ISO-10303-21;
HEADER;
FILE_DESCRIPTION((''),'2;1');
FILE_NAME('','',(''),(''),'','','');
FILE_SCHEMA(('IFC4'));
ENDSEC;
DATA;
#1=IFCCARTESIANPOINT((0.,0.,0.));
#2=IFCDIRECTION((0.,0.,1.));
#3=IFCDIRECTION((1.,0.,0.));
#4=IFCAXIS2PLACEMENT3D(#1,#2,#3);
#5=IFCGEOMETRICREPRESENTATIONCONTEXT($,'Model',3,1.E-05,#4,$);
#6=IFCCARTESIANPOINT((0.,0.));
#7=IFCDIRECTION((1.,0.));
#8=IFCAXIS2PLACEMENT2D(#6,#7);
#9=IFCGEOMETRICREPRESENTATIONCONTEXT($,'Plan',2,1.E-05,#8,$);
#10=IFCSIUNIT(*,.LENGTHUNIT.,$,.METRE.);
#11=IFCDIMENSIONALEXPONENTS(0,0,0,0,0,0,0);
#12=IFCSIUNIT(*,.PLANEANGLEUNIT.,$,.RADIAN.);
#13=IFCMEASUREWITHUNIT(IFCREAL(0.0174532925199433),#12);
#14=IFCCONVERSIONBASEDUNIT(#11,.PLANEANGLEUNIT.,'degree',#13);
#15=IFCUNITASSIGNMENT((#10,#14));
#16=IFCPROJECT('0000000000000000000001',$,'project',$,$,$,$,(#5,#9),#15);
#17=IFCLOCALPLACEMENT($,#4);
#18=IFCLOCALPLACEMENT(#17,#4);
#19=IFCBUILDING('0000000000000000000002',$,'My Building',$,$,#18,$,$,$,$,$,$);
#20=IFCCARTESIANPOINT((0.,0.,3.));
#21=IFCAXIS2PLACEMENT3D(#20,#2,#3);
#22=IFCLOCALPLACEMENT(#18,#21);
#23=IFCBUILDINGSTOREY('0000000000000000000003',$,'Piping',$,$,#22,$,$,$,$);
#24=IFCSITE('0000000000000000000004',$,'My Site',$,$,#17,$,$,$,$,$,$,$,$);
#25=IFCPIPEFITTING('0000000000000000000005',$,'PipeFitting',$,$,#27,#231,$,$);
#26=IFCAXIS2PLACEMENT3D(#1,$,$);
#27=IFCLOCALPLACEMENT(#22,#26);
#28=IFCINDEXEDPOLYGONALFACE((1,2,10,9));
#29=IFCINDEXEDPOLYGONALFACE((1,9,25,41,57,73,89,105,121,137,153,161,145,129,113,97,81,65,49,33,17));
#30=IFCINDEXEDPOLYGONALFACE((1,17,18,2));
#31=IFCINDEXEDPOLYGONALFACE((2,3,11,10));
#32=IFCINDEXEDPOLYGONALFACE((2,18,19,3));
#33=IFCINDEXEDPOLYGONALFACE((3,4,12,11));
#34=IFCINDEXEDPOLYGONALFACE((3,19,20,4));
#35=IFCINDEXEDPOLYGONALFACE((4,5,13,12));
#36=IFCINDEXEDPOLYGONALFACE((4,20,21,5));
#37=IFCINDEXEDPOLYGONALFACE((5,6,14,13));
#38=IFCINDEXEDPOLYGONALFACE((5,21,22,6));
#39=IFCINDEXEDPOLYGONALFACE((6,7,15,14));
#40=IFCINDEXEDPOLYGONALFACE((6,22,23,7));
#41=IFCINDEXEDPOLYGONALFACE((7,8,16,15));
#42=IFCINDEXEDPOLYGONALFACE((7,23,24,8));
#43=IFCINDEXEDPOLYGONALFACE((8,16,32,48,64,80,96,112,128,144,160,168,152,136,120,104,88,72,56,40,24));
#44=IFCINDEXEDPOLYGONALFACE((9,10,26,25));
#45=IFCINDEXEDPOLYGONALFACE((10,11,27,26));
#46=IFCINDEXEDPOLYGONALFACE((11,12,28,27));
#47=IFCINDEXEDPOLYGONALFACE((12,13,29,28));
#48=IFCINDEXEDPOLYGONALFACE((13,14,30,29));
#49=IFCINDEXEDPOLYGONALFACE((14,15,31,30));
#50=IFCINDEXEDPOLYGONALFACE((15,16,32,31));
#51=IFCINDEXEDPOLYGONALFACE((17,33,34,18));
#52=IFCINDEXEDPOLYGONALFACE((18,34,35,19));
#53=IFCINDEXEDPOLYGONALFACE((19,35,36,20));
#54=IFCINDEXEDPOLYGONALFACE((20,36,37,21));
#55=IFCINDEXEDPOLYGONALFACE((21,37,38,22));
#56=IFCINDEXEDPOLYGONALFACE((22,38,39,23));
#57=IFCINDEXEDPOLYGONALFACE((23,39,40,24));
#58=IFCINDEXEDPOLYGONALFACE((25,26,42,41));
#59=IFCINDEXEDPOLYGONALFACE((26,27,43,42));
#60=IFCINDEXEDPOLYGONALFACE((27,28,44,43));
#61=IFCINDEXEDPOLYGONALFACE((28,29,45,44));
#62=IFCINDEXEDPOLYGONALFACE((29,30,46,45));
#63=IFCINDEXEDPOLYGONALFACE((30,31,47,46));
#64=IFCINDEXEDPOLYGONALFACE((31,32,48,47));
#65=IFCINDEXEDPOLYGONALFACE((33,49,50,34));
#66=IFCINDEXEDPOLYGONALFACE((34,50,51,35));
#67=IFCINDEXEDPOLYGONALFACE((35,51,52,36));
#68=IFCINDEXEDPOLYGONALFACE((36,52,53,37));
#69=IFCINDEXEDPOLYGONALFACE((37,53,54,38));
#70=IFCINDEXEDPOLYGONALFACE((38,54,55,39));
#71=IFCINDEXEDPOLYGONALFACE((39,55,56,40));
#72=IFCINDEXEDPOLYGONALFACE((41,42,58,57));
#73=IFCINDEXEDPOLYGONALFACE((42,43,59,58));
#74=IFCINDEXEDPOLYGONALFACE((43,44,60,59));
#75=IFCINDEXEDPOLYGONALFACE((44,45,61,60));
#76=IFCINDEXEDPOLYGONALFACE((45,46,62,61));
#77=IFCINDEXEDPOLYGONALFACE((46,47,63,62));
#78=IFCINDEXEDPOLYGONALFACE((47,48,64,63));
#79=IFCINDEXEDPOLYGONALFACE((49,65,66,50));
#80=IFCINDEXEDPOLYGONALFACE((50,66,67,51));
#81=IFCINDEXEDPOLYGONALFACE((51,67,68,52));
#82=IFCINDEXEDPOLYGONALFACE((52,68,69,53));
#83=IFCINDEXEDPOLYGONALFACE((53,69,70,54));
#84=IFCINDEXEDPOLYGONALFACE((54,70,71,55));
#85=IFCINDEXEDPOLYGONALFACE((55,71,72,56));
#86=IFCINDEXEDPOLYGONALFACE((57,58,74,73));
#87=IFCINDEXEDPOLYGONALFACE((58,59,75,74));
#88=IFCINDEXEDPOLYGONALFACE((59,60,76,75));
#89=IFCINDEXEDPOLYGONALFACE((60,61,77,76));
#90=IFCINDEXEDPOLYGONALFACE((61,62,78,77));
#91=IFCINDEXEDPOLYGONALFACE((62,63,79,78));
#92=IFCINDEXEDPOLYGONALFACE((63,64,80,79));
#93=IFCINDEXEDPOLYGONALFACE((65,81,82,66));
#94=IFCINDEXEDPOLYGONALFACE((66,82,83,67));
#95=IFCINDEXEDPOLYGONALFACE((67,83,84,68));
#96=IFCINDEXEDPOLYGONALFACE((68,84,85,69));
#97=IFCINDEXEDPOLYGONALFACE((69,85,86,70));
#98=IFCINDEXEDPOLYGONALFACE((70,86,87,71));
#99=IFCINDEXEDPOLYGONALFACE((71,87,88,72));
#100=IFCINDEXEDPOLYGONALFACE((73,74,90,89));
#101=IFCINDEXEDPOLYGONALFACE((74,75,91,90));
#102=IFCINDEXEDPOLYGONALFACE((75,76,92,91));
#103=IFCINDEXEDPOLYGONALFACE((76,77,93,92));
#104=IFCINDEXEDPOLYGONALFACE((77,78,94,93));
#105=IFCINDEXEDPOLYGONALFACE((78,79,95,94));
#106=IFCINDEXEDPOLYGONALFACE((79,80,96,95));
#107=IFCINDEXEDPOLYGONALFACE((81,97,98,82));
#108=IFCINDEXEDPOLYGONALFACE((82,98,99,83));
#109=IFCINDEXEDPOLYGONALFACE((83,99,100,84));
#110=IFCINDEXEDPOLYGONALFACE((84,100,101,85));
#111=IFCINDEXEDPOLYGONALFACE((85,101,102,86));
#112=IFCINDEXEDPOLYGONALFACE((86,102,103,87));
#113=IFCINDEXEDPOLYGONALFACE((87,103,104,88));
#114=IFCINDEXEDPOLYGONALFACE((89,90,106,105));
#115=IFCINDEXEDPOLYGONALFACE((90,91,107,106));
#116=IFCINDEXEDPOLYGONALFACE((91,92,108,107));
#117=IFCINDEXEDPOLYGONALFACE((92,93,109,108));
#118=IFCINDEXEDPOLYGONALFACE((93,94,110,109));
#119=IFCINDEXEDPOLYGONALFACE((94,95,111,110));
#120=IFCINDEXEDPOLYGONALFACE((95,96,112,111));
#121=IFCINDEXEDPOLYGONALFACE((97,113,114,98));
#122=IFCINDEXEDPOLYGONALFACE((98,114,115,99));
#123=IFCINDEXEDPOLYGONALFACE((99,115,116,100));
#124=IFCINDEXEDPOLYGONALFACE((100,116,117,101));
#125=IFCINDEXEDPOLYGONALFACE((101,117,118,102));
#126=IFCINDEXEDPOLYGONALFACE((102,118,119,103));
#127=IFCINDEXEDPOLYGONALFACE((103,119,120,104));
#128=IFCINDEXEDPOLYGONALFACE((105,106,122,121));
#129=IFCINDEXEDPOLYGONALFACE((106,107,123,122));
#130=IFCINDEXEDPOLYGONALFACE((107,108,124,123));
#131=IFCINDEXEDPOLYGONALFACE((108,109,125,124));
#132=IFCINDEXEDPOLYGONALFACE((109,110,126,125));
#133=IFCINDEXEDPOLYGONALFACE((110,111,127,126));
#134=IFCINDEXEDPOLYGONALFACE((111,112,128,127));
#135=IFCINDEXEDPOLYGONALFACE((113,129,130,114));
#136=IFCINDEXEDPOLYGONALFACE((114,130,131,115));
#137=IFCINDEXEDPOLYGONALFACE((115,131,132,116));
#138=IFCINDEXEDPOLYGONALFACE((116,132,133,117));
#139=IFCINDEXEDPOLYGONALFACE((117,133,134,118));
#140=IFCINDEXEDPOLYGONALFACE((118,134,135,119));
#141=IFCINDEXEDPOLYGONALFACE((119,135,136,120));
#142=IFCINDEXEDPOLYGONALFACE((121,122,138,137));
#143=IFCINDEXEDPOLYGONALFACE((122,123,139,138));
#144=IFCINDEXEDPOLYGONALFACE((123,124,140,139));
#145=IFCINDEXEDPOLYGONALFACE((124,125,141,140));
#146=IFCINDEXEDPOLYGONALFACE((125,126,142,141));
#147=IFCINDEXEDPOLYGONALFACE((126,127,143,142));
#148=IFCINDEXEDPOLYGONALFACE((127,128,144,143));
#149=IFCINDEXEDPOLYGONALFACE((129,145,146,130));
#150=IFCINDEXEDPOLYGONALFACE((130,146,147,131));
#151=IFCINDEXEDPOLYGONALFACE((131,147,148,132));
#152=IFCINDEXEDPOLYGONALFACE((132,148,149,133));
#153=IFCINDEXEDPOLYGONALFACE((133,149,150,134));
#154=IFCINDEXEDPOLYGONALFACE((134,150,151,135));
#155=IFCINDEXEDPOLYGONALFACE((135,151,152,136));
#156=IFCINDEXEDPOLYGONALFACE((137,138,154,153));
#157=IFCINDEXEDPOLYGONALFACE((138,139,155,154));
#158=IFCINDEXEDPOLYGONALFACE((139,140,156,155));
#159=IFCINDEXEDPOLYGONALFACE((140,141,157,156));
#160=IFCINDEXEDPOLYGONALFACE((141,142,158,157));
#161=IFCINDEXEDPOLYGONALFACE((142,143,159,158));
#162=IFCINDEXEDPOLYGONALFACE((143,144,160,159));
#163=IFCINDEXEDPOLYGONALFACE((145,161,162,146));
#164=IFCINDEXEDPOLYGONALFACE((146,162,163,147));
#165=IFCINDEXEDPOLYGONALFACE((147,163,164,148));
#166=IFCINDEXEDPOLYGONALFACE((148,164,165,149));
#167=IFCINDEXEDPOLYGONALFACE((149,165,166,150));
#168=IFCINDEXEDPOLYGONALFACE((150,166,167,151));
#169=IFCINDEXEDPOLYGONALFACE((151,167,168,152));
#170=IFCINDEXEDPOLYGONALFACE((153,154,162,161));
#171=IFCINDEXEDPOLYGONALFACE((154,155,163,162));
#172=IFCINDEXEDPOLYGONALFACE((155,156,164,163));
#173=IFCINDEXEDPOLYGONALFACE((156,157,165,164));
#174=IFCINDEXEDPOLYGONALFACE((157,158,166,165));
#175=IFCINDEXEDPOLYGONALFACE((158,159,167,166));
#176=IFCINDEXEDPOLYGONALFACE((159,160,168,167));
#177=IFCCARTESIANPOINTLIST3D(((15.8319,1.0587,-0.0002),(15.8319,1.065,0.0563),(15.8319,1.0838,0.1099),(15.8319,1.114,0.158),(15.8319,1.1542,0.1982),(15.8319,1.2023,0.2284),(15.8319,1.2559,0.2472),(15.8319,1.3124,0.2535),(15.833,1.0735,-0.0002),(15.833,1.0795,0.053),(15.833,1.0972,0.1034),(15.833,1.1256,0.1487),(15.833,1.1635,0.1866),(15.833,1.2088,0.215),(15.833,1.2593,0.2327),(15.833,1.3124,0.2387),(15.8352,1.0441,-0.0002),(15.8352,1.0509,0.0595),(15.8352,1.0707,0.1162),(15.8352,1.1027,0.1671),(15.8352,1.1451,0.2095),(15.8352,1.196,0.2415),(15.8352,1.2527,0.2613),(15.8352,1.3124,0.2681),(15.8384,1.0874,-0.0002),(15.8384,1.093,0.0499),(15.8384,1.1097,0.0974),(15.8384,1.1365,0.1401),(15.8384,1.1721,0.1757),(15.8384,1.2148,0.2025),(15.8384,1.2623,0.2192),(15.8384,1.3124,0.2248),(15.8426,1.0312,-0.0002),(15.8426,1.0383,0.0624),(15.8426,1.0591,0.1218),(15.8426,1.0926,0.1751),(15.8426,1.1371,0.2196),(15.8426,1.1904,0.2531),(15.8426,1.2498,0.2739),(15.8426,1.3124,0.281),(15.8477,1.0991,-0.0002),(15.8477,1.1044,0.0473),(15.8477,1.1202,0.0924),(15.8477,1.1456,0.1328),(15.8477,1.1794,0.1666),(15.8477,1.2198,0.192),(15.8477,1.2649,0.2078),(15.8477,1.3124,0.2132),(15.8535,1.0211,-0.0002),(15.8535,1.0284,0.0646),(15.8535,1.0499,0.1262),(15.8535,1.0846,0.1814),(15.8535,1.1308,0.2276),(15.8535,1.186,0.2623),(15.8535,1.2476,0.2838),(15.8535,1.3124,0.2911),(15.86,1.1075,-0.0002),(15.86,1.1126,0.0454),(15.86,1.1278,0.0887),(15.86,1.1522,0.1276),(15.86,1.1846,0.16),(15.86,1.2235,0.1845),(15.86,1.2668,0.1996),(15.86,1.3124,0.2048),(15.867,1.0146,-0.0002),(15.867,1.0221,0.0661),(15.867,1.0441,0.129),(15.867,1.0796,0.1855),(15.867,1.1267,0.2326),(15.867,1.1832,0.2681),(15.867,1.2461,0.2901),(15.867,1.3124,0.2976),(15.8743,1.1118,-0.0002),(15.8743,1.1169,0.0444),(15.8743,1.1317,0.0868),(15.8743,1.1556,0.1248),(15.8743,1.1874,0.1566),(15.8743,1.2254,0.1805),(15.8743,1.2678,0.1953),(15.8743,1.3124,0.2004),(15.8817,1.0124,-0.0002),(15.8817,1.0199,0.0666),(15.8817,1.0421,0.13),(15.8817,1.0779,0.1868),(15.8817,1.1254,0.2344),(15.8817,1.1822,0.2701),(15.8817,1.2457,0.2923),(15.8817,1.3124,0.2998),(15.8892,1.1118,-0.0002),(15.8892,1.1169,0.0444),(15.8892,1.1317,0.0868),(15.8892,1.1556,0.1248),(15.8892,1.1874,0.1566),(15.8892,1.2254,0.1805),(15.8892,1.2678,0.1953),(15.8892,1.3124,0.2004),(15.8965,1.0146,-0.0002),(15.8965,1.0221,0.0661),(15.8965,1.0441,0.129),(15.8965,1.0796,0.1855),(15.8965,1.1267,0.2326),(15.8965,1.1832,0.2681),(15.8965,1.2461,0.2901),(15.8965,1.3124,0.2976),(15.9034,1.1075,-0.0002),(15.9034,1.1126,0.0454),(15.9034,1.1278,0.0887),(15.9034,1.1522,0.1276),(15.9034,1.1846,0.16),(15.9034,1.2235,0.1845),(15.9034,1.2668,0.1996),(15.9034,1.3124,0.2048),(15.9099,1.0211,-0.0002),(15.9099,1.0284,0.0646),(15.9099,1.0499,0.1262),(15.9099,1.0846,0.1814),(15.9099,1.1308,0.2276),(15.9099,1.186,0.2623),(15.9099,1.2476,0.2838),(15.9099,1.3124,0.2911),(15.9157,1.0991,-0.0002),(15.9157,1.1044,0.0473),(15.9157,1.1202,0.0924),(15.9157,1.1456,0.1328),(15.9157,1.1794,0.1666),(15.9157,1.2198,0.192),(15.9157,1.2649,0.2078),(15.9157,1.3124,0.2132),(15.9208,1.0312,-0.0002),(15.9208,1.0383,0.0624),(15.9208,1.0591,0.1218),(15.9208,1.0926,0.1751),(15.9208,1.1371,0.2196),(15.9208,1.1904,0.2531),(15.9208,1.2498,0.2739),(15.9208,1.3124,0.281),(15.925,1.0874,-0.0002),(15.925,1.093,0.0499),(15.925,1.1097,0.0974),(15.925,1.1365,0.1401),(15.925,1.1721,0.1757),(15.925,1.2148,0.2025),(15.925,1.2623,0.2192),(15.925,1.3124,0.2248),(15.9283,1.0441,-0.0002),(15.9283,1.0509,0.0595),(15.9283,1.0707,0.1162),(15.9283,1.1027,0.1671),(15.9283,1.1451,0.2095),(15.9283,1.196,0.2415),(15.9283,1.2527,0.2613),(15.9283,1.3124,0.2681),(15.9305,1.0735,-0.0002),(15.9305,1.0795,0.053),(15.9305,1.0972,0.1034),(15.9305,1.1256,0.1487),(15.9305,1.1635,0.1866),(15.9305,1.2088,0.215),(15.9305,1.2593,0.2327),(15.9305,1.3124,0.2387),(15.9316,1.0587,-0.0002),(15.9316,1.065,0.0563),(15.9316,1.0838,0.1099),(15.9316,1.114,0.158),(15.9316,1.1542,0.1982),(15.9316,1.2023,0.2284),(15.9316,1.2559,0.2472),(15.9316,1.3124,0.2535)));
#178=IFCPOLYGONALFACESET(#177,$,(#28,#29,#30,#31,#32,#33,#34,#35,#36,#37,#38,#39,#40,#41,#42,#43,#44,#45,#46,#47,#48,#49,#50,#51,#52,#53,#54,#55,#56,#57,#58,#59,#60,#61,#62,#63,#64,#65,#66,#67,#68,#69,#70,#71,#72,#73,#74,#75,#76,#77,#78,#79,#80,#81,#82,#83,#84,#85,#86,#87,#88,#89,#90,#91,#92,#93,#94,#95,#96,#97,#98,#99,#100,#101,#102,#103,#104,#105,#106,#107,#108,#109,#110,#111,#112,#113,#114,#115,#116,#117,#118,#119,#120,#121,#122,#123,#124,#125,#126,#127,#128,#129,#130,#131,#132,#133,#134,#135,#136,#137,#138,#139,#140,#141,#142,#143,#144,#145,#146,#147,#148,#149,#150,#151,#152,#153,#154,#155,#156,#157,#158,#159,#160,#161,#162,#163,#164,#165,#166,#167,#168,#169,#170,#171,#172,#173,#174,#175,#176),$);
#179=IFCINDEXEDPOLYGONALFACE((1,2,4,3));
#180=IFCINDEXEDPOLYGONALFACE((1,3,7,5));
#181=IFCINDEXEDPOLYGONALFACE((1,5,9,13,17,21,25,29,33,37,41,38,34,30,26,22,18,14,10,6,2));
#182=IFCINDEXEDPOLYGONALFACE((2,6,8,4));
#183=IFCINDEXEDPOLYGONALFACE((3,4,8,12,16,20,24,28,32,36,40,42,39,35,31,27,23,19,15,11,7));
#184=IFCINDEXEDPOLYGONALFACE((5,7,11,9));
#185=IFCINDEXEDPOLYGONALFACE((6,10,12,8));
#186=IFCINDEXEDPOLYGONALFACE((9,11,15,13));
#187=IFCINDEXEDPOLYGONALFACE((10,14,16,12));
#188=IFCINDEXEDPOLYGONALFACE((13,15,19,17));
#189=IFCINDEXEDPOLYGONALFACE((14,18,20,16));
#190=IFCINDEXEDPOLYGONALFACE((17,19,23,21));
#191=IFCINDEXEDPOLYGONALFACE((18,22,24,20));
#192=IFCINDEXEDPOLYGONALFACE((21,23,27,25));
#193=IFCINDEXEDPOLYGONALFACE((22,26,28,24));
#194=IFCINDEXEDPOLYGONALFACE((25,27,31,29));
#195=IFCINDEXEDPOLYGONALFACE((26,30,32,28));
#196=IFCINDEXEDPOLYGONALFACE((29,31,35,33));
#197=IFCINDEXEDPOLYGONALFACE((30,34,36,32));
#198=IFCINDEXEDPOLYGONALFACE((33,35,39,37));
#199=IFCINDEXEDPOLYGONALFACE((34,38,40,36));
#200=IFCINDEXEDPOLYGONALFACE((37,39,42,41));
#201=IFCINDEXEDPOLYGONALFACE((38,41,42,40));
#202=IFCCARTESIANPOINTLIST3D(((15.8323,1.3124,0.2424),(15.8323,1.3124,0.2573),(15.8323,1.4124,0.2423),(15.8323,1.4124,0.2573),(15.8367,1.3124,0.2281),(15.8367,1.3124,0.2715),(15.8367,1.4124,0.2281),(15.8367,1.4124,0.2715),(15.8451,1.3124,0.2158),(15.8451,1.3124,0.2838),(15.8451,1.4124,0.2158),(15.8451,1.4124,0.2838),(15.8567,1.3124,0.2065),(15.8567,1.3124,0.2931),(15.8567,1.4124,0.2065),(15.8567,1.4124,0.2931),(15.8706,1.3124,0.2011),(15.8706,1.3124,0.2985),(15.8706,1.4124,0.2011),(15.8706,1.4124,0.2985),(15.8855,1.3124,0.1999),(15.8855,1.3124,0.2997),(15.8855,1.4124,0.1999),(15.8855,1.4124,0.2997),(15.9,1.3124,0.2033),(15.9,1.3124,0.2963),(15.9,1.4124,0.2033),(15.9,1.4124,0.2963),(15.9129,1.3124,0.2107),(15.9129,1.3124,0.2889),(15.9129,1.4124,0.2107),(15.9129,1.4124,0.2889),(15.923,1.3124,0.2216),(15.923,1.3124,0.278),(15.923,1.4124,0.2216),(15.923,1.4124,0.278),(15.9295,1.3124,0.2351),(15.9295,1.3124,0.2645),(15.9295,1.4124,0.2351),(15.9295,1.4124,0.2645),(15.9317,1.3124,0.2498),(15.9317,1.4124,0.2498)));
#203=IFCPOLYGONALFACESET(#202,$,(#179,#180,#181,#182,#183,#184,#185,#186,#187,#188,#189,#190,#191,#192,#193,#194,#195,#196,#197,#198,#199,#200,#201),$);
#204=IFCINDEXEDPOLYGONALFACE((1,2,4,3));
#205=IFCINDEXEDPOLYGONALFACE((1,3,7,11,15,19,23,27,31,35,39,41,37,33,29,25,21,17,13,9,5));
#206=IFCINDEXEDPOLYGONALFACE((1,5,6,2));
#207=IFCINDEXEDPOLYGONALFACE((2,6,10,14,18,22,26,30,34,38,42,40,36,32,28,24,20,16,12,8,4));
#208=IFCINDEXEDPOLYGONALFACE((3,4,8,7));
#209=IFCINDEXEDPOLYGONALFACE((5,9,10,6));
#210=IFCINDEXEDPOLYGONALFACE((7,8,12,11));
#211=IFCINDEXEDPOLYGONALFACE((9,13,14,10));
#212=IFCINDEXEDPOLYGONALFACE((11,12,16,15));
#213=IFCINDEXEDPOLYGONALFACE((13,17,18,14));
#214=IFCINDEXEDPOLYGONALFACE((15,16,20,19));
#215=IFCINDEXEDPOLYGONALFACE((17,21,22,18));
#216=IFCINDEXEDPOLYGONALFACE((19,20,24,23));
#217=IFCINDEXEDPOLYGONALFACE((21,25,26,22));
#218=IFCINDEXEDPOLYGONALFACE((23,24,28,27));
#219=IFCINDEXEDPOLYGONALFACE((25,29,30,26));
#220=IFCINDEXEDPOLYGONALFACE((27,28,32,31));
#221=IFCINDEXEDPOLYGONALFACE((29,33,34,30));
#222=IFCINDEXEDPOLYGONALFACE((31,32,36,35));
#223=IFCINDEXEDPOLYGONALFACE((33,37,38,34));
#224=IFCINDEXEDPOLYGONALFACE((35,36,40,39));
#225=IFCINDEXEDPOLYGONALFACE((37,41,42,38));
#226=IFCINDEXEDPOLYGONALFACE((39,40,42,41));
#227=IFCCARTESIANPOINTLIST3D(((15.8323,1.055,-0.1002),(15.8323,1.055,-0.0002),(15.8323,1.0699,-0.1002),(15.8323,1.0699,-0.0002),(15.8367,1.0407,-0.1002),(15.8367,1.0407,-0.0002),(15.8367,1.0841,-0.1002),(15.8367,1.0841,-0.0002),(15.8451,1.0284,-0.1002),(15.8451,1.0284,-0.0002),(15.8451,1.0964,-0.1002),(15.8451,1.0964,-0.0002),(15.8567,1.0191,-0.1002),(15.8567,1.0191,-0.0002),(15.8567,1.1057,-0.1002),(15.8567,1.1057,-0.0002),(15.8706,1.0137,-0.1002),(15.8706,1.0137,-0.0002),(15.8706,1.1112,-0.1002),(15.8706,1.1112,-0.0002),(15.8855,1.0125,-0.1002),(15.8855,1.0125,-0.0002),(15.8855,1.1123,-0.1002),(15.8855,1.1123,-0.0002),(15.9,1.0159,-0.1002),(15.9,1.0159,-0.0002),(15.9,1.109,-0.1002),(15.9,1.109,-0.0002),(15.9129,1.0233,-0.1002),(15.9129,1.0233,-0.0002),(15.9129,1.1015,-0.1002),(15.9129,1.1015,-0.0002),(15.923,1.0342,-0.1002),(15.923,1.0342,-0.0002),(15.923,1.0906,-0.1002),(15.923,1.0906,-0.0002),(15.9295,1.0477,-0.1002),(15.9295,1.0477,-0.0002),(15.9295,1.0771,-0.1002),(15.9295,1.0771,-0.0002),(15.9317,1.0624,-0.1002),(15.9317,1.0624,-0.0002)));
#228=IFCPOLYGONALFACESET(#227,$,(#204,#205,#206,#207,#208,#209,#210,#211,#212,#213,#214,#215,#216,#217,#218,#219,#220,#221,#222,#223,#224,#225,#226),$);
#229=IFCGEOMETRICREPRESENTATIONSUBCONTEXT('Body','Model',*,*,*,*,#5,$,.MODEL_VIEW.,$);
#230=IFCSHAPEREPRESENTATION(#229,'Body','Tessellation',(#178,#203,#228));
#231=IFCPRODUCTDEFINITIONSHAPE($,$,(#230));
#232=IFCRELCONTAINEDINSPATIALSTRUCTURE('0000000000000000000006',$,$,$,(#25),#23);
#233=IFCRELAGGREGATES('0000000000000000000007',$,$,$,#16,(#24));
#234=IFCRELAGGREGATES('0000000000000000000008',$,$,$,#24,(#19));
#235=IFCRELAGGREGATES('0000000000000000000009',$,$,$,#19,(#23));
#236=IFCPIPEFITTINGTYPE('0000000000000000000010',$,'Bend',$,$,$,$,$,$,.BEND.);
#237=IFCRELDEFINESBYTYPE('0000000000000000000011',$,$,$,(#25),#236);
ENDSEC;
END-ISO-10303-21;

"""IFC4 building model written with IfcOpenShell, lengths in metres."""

from ifc_helpers import new_model, entity, si_unit, converted_unit, frame, origin_with_axes, origin_2d_with_axis, place, context, subcontext, project, spatial, circle, extrude, source, transform, mapped, type_object, type_shapes, element, save


model = new_model("IFC4")

# Units and contexts
model_context = context("Model", 3, precision=1e-05, world=origin_with_axes())
plan_context = context("Plan", 2, precision=1e-05, world=origin_2d_with_axis())
body_context = subcontext(model_context, "Body", "Model", "MODEL_VIEW")
ifc_project = project(units=[si_unit("LENGTHUNIT", "METRE"), converted_unit("PLANEANGLEUNIT", "degree", entity("IfcReal", 0.0174532925199433), si_unit("PLANEANGLEUNIT", "RADIAN"), dimensions=[0, 0, 0, 0, 0, 0, 0])], contexts=[model_context, plan_context])

# Site, building, storey
site_placement = place(None, origin_with_axes())
site = spatial("IfcSite", under=ifc_project, at=site_placement, Name="My Site")
building_placement = place(site_placement, origin_with_axes())
building = spatial("IfcBuilding", under=site, at=building_placement, Name="My Building")
storey_placement = place(building_placement, frame((0.0, 0.0, 3.0), z_axis=(0.0, 0.0, 1.0), x_axis=(1.0, 0.0, 0.0)))
storey = spatial("IfcBuildingStorey", under=building, at=storey_placement, Name="Piping")

# Pipe fitting
pipe_fitting_type_1 = type_object("IfcPipeFittingType", Name="Bend", PredefinedType="BEND")
shared_shape = source(origin_with_axes(), body_context, "Body", "SolidModel", [
    entity("IfcSweptDiskSolid", entity("IfcIndexedPolyCurve", entity("IfcCartesianPointList3D", [[0.0, 0.0, 0.1], [0.0, -0.0732, 0.2768], [0.0, -0.25, 0.35]]), [entity("IfcArcIndex", [1, 2, 3])]), 0.05),
    extrude(circle(Radius=0.05), origin_with_axes(), (0.0, 0.0, 1.0), 0.1),
    extrude(circle(Radius=0.05), frame((0.0, -0.25, 0.35), z_axis=(0.0, -1.0, -0.00003), x_axis=(1.0, 0.0, 0.0)), (0.0, 0.0, 1.0), 0.1),
])
type_shapes(pipe_fitting_type_1, [shared_shape])
for number, where, z_axis, x_axis, name in (
    (1, (15.8817, 1.4124, 0.2498), (0.0, -1.0, 0.000008), (1.0, 0.0, 0.0), "PipeFitting"),
):
    element("IfcPipeFitting", number, at=place(storey_placement, frame(where, z_axis=z_axis, x_axis=x_axis)), inside=storey, type_object=pipe_fitting_type_1, Name=name, context=body_context, shape_type="MappedRepresentation", body=[
        mapped(shared_shape, transform((0.0, 0.0, 0.0), x_axis=(1.0, 0.0, 0.0), y_axis=(0.0, 1.0, 0.0), z_axis=(0.0, 0.0, 1.0), scale=1.0)),
    ])

save(model, "model.ifc")
